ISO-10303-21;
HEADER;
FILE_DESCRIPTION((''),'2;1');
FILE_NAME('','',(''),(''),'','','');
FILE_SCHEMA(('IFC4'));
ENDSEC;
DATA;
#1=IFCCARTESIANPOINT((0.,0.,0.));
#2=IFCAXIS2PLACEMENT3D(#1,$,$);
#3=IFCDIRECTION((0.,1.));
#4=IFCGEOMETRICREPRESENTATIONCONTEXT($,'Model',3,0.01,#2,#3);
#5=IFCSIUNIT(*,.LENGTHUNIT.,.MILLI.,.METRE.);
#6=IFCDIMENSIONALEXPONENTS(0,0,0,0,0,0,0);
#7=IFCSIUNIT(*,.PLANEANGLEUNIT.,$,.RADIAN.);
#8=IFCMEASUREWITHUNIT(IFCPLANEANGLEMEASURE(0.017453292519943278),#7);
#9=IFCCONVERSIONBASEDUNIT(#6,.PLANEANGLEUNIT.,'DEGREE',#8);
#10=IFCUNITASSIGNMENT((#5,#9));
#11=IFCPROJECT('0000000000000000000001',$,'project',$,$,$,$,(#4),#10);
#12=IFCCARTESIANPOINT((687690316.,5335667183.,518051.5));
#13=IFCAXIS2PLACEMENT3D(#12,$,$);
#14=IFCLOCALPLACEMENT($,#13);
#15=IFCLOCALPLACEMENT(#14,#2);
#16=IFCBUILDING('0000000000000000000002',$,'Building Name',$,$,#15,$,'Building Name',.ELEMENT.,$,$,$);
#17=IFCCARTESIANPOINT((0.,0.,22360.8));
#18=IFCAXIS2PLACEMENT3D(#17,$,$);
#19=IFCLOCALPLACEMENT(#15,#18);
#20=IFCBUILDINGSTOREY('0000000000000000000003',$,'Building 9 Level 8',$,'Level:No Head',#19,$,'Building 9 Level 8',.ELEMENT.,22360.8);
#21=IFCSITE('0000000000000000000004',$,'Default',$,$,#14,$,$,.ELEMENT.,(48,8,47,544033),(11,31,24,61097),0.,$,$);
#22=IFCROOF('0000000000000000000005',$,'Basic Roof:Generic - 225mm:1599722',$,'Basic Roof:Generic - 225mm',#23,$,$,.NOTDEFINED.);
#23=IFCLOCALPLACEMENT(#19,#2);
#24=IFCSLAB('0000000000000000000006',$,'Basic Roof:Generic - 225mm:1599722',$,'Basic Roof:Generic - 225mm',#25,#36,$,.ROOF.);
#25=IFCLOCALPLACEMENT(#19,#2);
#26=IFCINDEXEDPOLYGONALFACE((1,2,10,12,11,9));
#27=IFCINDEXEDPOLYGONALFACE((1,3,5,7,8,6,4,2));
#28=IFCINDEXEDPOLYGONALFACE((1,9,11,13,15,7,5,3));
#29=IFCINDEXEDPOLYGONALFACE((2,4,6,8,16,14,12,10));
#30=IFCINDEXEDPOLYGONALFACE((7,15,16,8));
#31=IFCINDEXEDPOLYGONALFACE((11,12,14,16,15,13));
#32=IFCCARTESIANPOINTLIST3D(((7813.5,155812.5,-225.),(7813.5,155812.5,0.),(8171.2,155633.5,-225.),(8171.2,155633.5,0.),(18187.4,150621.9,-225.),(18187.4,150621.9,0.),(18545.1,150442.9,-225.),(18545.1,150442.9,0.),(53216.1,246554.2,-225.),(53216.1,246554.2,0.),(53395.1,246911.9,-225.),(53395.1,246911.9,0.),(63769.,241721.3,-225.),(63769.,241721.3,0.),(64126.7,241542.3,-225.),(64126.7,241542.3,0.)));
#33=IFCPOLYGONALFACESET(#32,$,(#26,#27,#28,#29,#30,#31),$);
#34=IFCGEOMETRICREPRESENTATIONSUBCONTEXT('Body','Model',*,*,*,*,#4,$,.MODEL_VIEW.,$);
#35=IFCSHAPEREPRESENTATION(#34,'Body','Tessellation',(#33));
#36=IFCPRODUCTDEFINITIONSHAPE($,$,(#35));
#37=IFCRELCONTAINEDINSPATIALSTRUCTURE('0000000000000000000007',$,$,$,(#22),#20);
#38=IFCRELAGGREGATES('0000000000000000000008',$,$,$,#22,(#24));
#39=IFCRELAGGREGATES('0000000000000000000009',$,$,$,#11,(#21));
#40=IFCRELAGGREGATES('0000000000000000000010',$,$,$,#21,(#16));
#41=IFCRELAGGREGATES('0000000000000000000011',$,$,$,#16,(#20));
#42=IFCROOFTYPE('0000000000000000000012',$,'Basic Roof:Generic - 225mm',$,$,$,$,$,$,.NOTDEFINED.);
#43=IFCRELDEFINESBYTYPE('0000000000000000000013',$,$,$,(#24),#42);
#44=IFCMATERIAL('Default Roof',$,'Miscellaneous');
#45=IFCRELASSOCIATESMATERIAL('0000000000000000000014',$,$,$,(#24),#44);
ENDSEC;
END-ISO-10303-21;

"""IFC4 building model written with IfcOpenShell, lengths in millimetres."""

from ifc_helpers import new_model, entity, si_unit, converted_unit, direction, frame, origin, place, context, subcontext, project, spatial, indexed_curve, outline, extrude, material, type_object, element, aggregate, save


model = new_model("IFC4")

# Units and contexts
model_context = context("Model", 3, precision=0.01, world=origin(), true_north=direction((0.0, 1.0)))
body_context = subcontext(model_context, "Body", "Model", "MODEL_VIEW")
ifc_project = project(units=[si_unit("LENGTHUNIT", "METRE", prefix="MILLI"), converted_unit("PLANEANGLEUNIT", "DEGREE", entity("IfcPlaneAngleMeasure", 0.017453292519943278), si_unit("PLANEANGLEUNIT", "RADIAN"), dimensions=[0, 0, 0, 0, 0, 0, 0])], contexts=[model_context])

# Site, building, storey
site_placement = place(None, frame((687690316.0, 5335667183.0, 518051.5)))
site = spatial("IfcSite", under=ifc_project, at=site_placement, Name="Default", CompositionType="ELEMENT", RefLatitude=(48, 8, 47, 544033), RefLongitude=(11, 31, 24, 61097), RefElevation=0.0)
building_placement = place(site_placement, origin())
building = spatial("IfcBuilding", under=site, at=building_placement, Name="Building Name", LongName="Building Name", CompositionType="ELEMENT")
storey_placement = place(building_placement, frame((0.0, 0.0, 22360.8)))
storey = spatial("IfcBuildingStorey", under=building, at=storey_placement, Name="Building 9 Level 8", ObjectType="Level:No Head", LongName="Building 9 Level 8", CompositionType="ELEMENT", Elevation=22360.8)

# Roof, slab
roof_placement = place(storey_placement, frame((7813.5, 150442.9, -225.0)))
roof = element("IfcRoof", 1, at=roof_placement, inside=storey, Name="Basic Roof:Generic - 225mm:1599722", ObjectType="Basic Roof:Generic - 225mm", PredefinedType="NOTDEFINED")
ifc_material = material(Name="Default Roof", Category="Miscellaneous")
roof_type = type_object("IfcRoofType", Name="Basic Roof:Generic - 225mm", PredefinedType="NOTDEFINED")
slab_placement = place(roof_placement, origin())
slab = element("IfcSlab", 2, at=slab_placement, type_object=roof_type, material=ifc_material, Name="Basic Roof:Generic - 225mm:1599722", ObjectType="Basic Roof:Generic - 225mm", PredefinedType="ROOF", context=body_context, shape_type="SweptSolid", body=[
    extrude(outline(indexed_curve([(-17425.0, -48234.5), (28156.6, 42864.9), (27798.9, 43043.9), (17425.0, 48234.5), (17246.0, 47876.8), (-28156.6, -42864.9), (-27798.9, -43043.9), (-17782.7, -48055.5), (-17425.0, -48234.5)], self_intersect=False)), frame((28156.6, 48234.5, 0.0)), (0.0, 0.0, 1.0), 225.0),
])
aggregate(roof, [slab])

save(model, "model.ifc")
